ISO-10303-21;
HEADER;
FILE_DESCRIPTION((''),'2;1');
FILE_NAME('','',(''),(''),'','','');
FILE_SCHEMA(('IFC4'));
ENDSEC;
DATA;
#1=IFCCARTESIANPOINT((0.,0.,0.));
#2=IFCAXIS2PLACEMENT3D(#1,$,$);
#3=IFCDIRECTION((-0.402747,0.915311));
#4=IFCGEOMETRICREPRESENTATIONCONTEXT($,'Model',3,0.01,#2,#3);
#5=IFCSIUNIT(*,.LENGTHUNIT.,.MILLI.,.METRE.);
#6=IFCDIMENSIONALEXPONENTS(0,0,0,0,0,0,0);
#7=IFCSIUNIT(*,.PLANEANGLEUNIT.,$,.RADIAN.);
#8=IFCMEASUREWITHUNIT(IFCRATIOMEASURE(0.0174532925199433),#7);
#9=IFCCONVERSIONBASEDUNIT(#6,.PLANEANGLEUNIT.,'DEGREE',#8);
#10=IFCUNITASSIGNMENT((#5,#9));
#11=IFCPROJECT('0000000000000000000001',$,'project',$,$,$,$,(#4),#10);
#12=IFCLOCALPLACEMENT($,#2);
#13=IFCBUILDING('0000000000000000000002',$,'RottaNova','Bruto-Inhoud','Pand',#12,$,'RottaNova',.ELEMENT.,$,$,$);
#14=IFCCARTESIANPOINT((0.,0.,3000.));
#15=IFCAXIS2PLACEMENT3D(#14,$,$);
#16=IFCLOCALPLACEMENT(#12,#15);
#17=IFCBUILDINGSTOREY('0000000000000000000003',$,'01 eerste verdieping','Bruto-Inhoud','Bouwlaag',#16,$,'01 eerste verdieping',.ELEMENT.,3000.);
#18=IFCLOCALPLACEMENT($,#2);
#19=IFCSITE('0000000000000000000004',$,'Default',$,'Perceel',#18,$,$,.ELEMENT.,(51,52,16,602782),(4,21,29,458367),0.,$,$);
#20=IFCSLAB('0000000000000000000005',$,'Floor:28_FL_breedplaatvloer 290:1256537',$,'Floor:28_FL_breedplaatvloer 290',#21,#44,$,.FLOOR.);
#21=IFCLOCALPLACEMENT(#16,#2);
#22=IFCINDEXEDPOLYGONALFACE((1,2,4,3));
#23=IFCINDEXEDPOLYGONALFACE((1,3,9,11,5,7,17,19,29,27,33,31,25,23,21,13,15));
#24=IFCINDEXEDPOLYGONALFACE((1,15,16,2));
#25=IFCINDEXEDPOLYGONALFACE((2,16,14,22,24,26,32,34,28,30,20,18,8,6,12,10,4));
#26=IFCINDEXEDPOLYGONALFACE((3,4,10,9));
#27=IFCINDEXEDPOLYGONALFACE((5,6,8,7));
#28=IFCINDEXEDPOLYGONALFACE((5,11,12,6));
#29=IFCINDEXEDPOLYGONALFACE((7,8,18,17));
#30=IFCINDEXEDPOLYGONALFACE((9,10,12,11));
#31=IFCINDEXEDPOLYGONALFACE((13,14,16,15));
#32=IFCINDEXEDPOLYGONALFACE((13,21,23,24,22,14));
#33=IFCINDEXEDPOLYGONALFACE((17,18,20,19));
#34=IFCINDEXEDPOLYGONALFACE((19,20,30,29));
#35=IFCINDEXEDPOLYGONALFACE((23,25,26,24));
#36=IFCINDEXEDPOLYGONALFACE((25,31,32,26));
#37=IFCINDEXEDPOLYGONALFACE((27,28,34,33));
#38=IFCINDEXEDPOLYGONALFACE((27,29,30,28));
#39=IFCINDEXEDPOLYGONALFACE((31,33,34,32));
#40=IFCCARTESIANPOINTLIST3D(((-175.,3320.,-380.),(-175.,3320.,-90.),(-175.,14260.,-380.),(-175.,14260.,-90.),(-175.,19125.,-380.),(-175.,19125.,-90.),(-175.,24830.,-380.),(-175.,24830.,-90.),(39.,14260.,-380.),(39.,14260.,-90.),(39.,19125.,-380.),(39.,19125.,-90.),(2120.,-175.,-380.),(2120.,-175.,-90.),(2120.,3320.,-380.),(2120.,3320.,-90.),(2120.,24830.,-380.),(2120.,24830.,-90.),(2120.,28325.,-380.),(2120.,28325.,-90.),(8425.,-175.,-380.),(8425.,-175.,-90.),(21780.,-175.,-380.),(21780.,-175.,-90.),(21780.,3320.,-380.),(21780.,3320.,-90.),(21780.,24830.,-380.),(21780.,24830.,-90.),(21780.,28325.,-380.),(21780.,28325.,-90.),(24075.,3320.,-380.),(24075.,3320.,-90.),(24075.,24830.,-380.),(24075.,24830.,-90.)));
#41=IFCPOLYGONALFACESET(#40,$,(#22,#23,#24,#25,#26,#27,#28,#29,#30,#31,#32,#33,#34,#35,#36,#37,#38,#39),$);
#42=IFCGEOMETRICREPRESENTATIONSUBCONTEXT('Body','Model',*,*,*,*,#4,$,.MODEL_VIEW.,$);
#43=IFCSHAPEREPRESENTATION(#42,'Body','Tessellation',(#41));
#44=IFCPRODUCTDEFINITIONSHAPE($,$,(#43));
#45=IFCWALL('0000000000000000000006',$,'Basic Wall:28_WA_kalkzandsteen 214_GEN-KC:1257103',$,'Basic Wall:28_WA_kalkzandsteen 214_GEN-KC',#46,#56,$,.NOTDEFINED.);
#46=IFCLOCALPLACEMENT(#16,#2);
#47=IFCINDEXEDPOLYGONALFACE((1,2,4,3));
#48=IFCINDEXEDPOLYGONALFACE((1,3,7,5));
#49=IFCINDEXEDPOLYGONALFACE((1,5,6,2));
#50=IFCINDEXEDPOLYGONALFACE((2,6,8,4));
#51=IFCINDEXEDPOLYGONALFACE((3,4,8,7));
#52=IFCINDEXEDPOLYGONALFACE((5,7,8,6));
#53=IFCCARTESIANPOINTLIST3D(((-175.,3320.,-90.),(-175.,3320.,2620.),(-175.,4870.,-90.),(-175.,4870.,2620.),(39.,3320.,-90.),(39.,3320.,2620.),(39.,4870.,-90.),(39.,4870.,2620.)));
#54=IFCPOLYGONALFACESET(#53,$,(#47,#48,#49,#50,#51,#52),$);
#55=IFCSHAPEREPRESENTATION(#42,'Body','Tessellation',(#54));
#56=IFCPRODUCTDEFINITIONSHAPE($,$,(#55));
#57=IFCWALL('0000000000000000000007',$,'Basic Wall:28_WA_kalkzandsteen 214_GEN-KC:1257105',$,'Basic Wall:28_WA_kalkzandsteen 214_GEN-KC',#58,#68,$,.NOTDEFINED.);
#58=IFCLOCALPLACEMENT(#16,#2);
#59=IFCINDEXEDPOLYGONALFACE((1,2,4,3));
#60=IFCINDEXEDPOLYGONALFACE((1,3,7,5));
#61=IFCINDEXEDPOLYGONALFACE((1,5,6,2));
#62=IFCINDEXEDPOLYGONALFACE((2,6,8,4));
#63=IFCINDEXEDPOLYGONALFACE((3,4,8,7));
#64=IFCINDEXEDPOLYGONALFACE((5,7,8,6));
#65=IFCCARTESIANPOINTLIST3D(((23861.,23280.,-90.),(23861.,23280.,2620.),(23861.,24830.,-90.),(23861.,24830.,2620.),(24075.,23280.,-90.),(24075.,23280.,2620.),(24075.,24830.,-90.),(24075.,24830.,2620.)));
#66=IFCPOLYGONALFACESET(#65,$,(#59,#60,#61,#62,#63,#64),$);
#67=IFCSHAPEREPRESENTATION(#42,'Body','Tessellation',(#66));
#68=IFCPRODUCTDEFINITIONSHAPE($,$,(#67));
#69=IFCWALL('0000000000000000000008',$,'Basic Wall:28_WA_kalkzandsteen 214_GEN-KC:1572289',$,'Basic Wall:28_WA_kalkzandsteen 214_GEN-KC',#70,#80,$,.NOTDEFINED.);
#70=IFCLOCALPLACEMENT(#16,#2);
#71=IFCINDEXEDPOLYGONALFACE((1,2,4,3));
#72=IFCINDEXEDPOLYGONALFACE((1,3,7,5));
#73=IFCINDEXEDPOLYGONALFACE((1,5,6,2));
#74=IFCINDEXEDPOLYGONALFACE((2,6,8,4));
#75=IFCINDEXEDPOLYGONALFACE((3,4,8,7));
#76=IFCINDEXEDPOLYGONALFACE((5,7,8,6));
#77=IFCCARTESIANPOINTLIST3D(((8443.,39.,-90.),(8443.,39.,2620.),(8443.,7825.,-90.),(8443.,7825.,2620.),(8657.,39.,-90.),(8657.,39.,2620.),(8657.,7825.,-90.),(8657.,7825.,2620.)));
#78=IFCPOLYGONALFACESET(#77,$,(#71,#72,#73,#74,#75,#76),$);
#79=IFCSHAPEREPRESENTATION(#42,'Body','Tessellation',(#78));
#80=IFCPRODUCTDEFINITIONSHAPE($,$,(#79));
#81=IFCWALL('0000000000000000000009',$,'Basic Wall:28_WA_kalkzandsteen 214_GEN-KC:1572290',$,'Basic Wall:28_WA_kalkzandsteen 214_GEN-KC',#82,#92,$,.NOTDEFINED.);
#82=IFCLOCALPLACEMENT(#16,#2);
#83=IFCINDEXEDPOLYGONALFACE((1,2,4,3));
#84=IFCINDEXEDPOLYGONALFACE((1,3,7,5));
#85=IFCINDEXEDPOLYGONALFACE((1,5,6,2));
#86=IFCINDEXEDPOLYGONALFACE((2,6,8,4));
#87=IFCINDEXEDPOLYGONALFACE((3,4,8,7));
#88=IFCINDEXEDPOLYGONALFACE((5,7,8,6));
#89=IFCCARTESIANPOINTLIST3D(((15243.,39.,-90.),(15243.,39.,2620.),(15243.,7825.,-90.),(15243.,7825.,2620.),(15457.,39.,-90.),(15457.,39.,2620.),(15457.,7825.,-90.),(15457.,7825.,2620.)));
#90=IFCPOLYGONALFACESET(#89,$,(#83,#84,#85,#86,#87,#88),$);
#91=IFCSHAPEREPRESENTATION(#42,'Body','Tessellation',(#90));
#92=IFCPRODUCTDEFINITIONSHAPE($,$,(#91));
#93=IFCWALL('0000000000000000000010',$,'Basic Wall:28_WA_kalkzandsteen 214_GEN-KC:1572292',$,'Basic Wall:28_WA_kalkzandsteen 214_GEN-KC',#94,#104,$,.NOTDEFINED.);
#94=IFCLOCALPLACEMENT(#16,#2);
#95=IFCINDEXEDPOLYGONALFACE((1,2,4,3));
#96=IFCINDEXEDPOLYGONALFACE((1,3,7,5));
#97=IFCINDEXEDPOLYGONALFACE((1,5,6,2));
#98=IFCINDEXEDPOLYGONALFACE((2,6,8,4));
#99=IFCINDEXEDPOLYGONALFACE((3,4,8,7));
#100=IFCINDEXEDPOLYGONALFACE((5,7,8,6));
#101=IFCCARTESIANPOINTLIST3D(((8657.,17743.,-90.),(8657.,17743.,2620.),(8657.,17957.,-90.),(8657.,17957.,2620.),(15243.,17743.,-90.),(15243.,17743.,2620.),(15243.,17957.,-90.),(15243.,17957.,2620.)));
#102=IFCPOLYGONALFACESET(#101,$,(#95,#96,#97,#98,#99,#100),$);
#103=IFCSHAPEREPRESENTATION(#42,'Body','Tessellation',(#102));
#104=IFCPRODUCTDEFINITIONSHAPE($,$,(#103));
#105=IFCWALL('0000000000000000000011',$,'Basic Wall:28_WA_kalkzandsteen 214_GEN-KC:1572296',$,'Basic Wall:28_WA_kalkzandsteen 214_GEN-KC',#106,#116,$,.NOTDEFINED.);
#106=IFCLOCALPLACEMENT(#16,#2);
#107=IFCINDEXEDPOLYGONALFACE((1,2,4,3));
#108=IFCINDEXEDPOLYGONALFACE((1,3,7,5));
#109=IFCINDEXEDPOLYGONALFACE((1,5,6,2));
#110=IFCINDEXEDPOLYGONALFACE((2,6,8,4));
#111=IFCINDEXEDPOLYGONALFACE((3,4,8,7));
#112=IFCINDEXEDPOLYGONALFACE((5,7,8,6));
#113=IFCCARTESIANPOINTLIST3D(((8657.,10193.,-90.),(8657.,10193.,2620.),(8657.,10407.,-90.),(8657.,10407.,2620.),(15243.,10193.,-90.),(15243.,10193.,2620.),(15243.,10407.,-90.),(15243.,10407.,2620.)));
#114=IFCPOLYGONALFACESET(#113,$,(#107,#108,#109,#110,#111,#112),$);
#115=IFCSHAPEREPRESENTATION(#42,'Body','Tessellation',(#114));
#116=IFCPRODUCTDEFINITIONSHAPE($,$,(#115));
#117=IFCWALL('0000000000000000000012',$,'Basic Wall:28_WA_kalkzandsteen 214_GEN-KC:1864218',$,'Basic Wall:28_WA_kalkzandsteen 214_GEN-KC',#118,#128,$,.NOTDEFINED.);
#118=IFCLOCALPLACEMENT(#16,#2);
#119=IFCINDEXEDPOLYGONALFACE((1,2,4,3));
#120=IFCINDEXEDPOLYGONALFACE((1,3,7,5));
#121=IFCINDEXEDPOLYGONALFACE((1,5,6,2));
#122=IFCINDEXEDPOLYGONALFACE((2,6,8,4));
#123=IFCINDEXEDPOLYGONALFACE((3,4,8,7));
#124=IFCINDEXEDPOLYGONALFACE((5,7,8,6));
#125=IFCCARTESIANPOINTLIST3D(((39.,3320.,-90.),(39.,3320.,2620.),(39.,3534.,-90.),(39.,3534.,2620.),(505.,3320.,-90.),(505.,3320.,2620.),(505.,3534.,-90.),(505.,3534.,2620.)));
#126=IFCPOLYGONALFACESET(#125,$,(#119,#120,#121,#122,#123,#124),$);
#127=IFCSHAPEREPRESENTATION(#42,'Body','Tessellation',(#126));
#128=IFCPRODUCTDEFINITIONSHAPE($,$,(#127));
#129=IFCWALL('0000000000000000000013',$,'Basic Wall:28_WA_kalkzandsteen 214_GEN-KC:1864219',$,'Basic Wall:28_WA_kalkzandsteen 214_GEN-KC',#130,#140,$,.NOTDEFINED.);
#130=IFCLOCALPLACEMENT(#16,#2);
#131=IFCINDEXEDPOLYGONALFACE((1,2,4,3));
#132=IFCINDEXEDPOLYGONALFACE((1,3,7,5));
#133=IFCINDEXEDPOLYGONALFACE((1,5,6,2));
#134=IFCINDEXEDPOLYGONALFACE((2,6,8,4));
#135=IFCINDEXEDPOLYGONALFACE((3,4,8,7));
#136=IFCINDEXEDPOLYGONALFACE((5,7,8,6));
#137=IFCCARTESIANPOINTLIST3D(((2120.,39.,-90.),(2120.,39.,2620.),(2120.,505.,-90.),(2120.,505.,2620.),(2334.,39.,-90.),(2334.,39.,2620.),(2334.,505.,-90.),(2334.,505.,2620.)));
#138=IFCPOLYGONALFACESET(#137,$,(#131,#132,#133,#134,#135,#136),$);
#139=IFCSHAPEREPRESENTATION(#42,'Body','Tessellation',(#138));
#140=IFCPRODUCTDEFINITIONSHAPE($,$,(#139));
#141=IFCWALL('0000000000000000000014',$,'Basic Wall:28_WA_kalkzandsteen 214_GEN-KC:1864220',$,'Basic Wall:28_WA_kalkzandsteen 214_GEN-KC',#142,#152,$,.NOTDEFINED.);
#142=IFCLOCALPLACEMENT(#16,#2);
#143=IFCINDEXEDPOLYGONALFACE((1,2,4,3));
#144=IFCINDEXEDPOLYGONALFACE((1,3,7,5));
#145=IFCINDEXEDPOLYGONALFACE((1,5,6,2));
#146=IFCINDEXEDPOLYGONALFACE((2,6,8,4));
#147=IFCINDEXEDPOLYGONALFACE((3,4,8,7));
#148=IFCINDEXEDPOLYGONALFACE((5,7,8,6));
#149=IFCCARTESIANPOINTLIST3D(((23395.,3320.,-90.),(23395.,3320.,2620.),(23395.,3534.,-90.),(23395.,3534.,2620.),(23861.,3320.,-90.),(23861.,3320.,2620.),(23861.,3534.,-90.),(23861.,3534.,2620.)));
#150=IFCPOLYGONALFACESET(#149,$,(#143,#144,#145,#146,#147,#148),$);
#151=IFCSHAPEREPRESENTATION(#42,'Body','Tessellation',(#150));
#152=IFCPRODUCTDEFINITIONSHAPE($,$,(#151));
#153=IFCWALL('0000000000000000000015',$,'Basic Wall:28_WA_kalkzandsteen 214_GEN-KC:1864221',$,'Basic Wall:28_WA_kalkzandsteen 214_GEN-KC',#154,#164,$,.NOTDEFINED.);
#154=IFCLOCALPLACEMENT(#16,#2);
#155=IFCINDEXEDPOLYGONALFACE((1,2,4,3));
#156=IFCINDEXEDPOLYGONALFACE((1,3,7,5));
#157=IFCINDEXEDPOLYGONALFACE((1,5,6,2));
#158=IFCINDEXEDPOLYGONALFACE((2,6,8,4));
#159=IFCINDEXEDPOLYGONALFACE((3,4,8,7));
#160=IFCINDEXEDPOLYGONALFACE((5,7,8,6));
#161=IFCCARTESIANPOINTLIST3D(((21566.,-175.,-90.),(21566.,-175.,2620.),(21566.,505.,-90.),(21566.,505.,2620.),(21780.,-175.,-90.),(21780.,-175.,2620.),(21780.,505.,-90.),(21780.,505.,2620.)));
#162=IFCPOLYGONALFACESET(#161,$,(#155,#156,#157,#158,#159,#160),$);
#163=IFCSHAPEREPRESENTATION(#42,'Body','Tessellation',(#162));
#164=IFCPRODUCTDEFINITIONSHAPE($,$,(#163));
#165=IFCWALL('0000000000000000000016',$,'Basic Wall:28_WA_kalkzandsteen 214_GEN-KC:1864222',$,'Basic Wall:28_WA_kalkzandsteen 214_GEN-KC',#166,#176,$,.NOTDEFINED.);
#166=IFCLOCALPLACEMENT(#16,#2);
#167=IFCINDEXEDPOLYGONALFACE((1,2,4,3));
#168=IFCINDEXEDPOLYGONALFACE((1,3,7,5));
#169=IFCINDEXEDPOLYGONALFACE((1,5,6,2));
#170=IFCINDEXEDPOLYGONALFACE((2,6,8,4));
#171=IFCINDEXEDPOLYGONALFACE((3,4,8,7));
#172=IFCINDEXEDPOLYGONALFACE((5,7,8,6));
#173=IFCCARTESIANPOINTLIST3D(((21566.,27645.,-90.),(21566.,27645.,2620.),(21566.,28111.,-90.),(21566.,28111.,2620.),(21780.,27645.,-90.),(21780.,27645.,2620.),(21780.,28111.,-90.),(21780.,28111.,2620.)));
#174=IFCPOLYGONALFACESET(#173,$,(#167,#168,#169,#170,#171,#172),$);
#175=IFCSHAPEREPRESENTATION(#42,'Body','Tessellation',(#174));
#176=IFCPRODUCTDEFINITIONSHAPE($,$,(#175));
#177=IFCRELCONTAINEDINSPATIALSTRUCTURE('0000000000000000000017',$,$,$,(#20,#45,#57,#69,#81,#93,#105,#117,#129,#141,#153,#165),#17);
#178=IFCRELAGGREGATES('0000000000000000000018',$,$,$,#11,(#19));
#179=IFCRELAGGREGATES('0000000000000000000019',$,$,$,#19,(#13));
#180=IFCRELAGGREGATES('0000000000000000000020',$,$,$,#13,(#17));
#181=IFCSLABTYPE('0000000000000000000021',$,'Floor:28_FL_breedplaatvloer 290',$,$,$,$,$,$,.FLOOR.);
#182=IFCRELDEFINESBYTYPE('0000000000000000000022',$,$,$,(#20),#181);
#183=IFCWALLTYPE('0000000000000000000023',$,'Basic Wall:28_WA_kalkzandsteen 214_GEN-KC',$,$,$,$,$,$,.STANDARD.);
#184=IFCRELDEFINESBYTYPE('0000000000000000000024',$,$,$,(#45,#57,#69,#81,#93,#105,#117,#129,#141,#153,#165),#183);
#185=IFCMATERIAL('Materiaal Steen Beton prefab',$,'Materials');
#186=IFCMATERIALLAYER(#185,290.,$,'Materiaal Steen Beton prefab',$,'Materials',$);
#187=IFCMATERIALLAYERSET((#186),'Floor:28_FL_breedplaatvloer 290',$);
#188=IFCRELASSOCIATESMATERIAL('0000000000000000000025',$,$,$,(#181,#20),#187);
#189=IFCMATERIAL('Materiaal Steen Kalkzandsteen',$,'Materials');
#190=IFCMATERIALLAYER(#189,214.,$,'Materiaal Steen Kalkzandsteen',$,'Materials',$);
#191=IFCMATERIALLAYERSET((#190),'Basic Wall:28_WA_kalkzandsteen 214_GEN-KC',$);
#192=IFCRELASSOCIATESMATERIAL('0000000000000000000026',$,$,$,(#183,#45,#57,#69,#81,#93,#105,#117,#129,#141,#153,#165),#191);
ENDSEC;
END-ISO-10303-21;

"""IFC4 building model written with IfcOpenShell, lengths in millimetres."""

from ifc_helpers import new_model, entity, si_unit, converted_unit, direction, frame, frame_2d, origin, origin_2d_with_axis, place, context, subcontext, project, spatial, polyline, rectangle, outline, extrude, material, layer, layer_set, layer_usage, type_object, element, save


model = new_model("IFC4")

# Units and contexts
model_context = context("Model", 3, precision=0.01, world=origin(), true_north=direction((-0.402747, 0.915311)))
body_context = subcontext(model_context, "Body", "Model", "MODEL_VIEW")
ifc_project = project(units=[si_unit("LENGTHUNIT", "METRE", prefix="MILLI"), converted_unit("PLANEANGLEUNIT", "DEGREE", entity("IfcRatioMeasure", 0.0174532925199433), si_unit("PLANEANGLEUNIT", "RADIAN"), dimensions=[0, 0, 0, 0, 0, 0, 0])], contexts=[model_context])

# Site, building, storey
site_placement = place(None, origin())
site = spatial("IfcSite", under=ifc_project, at=site_placement, Name="Default", ObjectType="Perceel", CompositionType="ELEMENT", RefLatitude=(51, 52, 16, 602782), RefLongitude=(4, 21, 29, 458367), RefElevation=0.0)
building_placement = place(None, origin())
building = spatial("IfcBuilding", under=site, at=building_placement, Name="RottaNova", Description="Bruto-Inhoud", ObjectType="Pand", LongName="RottaNova", CompositionType="ELEMENT")
storey_placement = place(building_placement, frame((0.0, 0.0, 3000.0)))
storey = spatial("IfcBuildingStorey", under=building, at=storey_placement, Name="01 eerste verdieping", Description="Bruto-Inhoud", ObjectType="Bouwlaag", LongName="01 eerste verdieping", CompositionType="ELEMENT", Elevation=3000.0)

# Slab
ifc_material_1 = material(Name="Materiaal Steen Beton prefab", Category="Materials")
ifc_layer_1 = layer(ifc_material_1, 290.0, Name="Materiaal Steen Beton prefab", Category="Materials")
ifc_layer_set_1 = layer_set([ifc_layer_1], Name="Floor:28_FL_breedplaatvloer 290")
ifc_layer_usage = layer_usage(ifc_layer_set_1, "AXIS3", "POSITIVE", 0.0)
slab_type = type_object("IfcSlabType", Name="Floor:28_FL_breedplaatvloer 290", PredefinedType="FLOOR", material=ifc_layer_set_1)
slab_placement = place(storey_placement, frame((-175.0, -175.0, -380.0)))
element("IfcSlab", 1, at=slab_placement, inside=storey, type_object=slab_type, material=ifc_layer_usage, Name="Floor:28_FL_breedplaatvloer 290:1256537", ObjectType="Floor:28_FL_breedplaatvloer 290", PredefinedType="FLOOR", context=body_context, shape_type="SweptSolid", body=[
    extrude(outline(polyline([(-9830.0, 14250.0), (-9830.0, 10755.0), (-12125.0, 10755.0), (-12125.0, -10755.0), (-9830.0, -10755.0), (-9830.0, -14250.0), (3525.0, -14250.0), (9830.0, -14250.0), (9830.0, -10755.0), (12125.0, -10755.0), (12125.0, 185.0), (11911.0, 185.0), (11911.0, 5050.0), (12125.0, 5050.0), (12125.0, 10755.0), (9830.0, 10755.0), (9830.0, 14250.0), (-9830.0, 14250.0)])), frame((12125.0, 14250.0, 290.0), z_axis=(0.0, 0.0, -1.0), x_axis=(-1.0, 0.0, 0.0)), (0.0, 0.0, 1.0), 290.0),
])

# Walls
ifc_material_2 = material(Name="Materiaal Steen Kalkzandsteen", Category="Materials")
ifc_layer_2 = layer(ifc_material_2, 214.0, Name="Materiaal Steen Kalkzandsteen", Category="Materials")
ifc_layer_set_2 = layer_set([ifc_layer_2], Name="Basic Wall:28_WA_kalkzandsteen 214_GEN-KC")
wall_type_1 = type_object("IfcWallType", Name="Basic Wall:28_WA_kalkzandsteen 214_GEN-KC", PredefinedType="STANDARD", material=ifc_layer_set_2)
wall_1_placement = place(storey_placement, frame((-68.0, 3320.0, -90.0), z_axis=(0.0, 0.0, 1.0), x_axis=(0.0, 1.0, 0.0)))
element("IfcWall", 2, at=wall_1_placement, inside=storey, type_object=wall_type_1, material=ifc_layer_set_2, Name="Basic Wall:28_WA_kalkzandsteen 214_GEN-KC:1257103", ObjectType="Basic Wall:28_WA_kalkzandsteen 214_GEN-KC", PredefinedType="NOTDEFINED", context=body_context, shape_type="SweptSolid", body=[
    extrude(rectangle(XDim=1550.0, YDim=214.0, at=frame_2d((775.0, 0.0), x_axis=(-1.0, 0.0))), origin(), (0.0, 0.0, 1.0), 2710.0),
])
wall_2_placement = place(storey_placement, frame((23968.0, 24830.0, -90.0), z_axis=(0.0, 0.0, 1.0), x_axis=(0.0, -1.0, 0.0)))
element("IfcWall", 3, at=wall_2_placement, inside=storey, type_object=wall_type_1, material=ifc_layer_set_2, Name="Basic Wall:28_WA_kalkzandsteen 214_GEN-KC:1257105", ObjectType="Basic Wall:28_WA_kalkzandsteen 214_GEN-KC", PredefinedType="NOTDEFINED", context=body_context, shape_type="SweptSolid", body=[
    extrude(rectangle(XDim=1550.0, YDim=214.0, at=frame_2d((775.0, 0.0), x_axis=(-1.0, 0.0))), origin(), (0.0, 0.0, 1.0), 2710.0),
])
wall_3_placement = place(storey_placement, frame((8550.0, 39.0, -90.0), z_axis=(0.0, 0.0, 1.0), x_axis=(0.0, 1.0, 0.0)))
element("IfcWall", 4, at=wall_3_placement, inside=storey, type_object=wall_type_1, material=ifc_layer_set_2, Name="Basic Wall:28_WA_kalkzandsteen 214_GEN-KC:1572289", ObjectType="Basic Wall:28_WA_kalkzandsteen 214_GEN-KC", PredefinedType="NOTDEFINED", context=body_context, shape_type="SweptSolid", body=[
    extrude(rectangle(XDim=7786.0, YDim=214.0, at=frame_2d((0.0, 0.0), x_axis=(1.0, 0.0))), frame((3893.0, 0.0, 0.0)), (0.0, 0.0, 1.0), 2710.0),
])
wall_4_placement = place(storey_placement, frame((15350.0, 39.0, -90.0), z_axis=(0.0, 0.0, 1.0), x_axis=(0.0, 1.0, 0.0)))
element("IfcWall", 5, at=wall_4_placement, inside=storey, type_object=wall_type_1, material=ifc_layer_set_2, Name="Basic Wall:28_WA_kalkzandsteen 214_GEN-KC:1572290", ObjectType="Basic Wall:28_WA_kalkzandsteen 214_GEN-KC", PredefinedType="NOTDEFINED", context=body_context, shape_type="SweptSolid", body=[
    extrude(rectangle(XDim=7786.0, YDim=214.0, at=origin_2d_with_axis()), frame((3893.0, 0.0, 0.0)), (0.0, 0.0, 1.0), 2710.0),
])
wall_5_placement = place(storey_placement, frame((8657.0, 17850.0, -90.0)))
element("IfcWall", 6, at=wall_5_placement, inside=storey, type_object=wall_type_1, material=ifc_layer_set_2, Name="Basic Wall:28_WA_kalkzandsteen 214_GEN-KC:1572292", ObjectType="Basic Wall:28_WA_kalkzandsteen 214_GEN-KC", PredefinedType="NOTDEFINED", context=body_context, shape_type="SweptSolid", body=[
    extrude(rectangle(XDim=6586.0, YDim=214.0, at=frame_2d((3293.0, 0.0), x_axis=(-1.0, 0.0))), origin(), (0.0, 0.0, 1.0), 2710.0),
])
wall_6_placement = place(storey_placement, frame((8657.0, 10300.0, -90.0)))
element("IfcWall", 7, at=wall_6_placement, inside=storey, type_object=wall_type_1, material=ifc_layer_set_2, Name="Basic Wall:28_WA_kalkzandsteen 214_GEN-KC:1572296", ObjectType="Basic Wall:28_WA_kalkzandsteen 214_GEN-KC", PredefinedType="NOTDEFINED", context=body_context, shape_type="SweptSolid", body=[
    extrude(rectangle(XDim=6586.0, YDim=214.0, at=frame_2d((3293.0, 0.0), x_axis=(-1.0, 0.0))), origin(), (0.0, 0.0, 1.0), 2710.0),
])
wall_7_placement = place(storey_placement, frame((39.0, 3427.0, -90.0)))
element("IfcWall", 8, at=wall_7_placement, inside=storey, type_object=wall_type_1, material=ifc_layer_set_2, Name="Basic Wall:28_WA_kalkzandsteen 214_GEN-KC:1864218", ObjectType="Basic Wall:28_WA_kalkzandsteen 214_GEN-KC", PredefinedType="NOTDEFINED", context=body_context, shape_type="SweptSolid", body=[
    extrude(rectangle(XDim=466.0, YDim=214.0, at=frame_2d((233.0, 0.0), x_axis=(-1.0, 0.0))), origin(), (0.0, 0.0, 1.0), 2710.0),
])
wall_8_placement = place(storey_placement, frame((2227.0, 505.0, -90.0), z_axis=(0.0, 0.0, 1.0), x_axis=(0.0, -1.0, 0.0)))
element("IfcWall", 9, at=wall_8_placement, inside=storey, type_object=wall_type_1, material=ifc_layer_set_2, Name="Basic Wall:28_WA_kalkzandsteen 214_GEN-KC:1864219", ObjectType="Basic Wall:28_WA_kalkzandsteen 214_GEN-KC", PredefinedType="NOTDEFINED", context=body_context, shape_type="SweptSolid", body=[
    extrude(rectangle(XDim=466.0, YDim=214.0, at=frame_2d((233.0, 0.0), x_axis=(-1.0, 0.0))), origin(), (0.0, 0.0, 1.0), 2710.0),
])
wall_9_placement = place(storey_placement, frame((23861.0, 3427.0, -90.0), z_axis=(0.0, 0.0, 1.0), x_axis=(-1.0, 0.0, 0.0)))
element("IfcWall", 10, at=wall_9_placement, inside=storey, type_object=wall_type_1, material=ifc_layer_set_2, Name="Basic Wall:28_WA_kalkzandsteen 214_GEN-KC:1864220", ObjectType="Basic Wall:28_WA_kalkzandsteen 214_GEN-KC", PredefinedType="NOTDEFINED", context=body_context, shape_type="SweptSolid", body=[
    extrude(rectangle(XDim=466.0, YDim=214.0, at=frame_2d((233.0, 0.0), x_axis=(-1.0, 0.0))), origin(), (0.0, 0.0, 1.0), 2710.0),
])
wall_10_placement = place(storey_placement, frame((21673.0, -175.0, -90.0), z_axis=(0.0, 0.0, 1.0), x_axis=(0.0, 1.0, 0.0)))
element("IfcWall", 11, at=wall_10_placement, inside=storey, type_object=wall_type_1, material=ifc_layer_set_2, Name="Basic Wall:28_WA_kalkzandsteen 214_GEN-KC:1864221", ObjectType="Basic Wall:28_WA_kalkzandsteen 214_GEN-KC", PredefinedType="NOTDEFINED", context=body_context, shape_type="SweptSolid", body=[
    extrude(rectangle(XDim=680.0, YDim=214.0, at=frame_2d((340.0, 0.0), x_axis=(-1.0, 0.0))), origin(), (0.0, 0.0, 1.0), 2710.0),
])
wall_11_placement = place(storey_placement, frame((21673.0, 28111.0, -90.0), z_axis=(0.0, 0.0, 1.0), x_axis=(0.0, -1.0, 0.0)))
element("IfcWall", 12, at=wall_11_placement, inside=storey, type_object=wall_type_1, material=ifc_layer_set_2, Name="Basic Wall:28_WA_kalkzandsteen 214_GEN-KC:1864222", ObjectType="Basic Wall:28_WA_kalkzandsteen 214_GEN-KC", PredefinedType="NOTDEFINED", context=body_context, shape_type="SweptSolid", body=[
    extrude(rectangle(XDim=466.0, YDim=214.0, at=frame_2d((233.0, 0.0), x_axis=(-1.0, 0.0))), origin(), (0.0, 0.0, 1.0), 2710.0),
])

save(model, "model.ifc")
